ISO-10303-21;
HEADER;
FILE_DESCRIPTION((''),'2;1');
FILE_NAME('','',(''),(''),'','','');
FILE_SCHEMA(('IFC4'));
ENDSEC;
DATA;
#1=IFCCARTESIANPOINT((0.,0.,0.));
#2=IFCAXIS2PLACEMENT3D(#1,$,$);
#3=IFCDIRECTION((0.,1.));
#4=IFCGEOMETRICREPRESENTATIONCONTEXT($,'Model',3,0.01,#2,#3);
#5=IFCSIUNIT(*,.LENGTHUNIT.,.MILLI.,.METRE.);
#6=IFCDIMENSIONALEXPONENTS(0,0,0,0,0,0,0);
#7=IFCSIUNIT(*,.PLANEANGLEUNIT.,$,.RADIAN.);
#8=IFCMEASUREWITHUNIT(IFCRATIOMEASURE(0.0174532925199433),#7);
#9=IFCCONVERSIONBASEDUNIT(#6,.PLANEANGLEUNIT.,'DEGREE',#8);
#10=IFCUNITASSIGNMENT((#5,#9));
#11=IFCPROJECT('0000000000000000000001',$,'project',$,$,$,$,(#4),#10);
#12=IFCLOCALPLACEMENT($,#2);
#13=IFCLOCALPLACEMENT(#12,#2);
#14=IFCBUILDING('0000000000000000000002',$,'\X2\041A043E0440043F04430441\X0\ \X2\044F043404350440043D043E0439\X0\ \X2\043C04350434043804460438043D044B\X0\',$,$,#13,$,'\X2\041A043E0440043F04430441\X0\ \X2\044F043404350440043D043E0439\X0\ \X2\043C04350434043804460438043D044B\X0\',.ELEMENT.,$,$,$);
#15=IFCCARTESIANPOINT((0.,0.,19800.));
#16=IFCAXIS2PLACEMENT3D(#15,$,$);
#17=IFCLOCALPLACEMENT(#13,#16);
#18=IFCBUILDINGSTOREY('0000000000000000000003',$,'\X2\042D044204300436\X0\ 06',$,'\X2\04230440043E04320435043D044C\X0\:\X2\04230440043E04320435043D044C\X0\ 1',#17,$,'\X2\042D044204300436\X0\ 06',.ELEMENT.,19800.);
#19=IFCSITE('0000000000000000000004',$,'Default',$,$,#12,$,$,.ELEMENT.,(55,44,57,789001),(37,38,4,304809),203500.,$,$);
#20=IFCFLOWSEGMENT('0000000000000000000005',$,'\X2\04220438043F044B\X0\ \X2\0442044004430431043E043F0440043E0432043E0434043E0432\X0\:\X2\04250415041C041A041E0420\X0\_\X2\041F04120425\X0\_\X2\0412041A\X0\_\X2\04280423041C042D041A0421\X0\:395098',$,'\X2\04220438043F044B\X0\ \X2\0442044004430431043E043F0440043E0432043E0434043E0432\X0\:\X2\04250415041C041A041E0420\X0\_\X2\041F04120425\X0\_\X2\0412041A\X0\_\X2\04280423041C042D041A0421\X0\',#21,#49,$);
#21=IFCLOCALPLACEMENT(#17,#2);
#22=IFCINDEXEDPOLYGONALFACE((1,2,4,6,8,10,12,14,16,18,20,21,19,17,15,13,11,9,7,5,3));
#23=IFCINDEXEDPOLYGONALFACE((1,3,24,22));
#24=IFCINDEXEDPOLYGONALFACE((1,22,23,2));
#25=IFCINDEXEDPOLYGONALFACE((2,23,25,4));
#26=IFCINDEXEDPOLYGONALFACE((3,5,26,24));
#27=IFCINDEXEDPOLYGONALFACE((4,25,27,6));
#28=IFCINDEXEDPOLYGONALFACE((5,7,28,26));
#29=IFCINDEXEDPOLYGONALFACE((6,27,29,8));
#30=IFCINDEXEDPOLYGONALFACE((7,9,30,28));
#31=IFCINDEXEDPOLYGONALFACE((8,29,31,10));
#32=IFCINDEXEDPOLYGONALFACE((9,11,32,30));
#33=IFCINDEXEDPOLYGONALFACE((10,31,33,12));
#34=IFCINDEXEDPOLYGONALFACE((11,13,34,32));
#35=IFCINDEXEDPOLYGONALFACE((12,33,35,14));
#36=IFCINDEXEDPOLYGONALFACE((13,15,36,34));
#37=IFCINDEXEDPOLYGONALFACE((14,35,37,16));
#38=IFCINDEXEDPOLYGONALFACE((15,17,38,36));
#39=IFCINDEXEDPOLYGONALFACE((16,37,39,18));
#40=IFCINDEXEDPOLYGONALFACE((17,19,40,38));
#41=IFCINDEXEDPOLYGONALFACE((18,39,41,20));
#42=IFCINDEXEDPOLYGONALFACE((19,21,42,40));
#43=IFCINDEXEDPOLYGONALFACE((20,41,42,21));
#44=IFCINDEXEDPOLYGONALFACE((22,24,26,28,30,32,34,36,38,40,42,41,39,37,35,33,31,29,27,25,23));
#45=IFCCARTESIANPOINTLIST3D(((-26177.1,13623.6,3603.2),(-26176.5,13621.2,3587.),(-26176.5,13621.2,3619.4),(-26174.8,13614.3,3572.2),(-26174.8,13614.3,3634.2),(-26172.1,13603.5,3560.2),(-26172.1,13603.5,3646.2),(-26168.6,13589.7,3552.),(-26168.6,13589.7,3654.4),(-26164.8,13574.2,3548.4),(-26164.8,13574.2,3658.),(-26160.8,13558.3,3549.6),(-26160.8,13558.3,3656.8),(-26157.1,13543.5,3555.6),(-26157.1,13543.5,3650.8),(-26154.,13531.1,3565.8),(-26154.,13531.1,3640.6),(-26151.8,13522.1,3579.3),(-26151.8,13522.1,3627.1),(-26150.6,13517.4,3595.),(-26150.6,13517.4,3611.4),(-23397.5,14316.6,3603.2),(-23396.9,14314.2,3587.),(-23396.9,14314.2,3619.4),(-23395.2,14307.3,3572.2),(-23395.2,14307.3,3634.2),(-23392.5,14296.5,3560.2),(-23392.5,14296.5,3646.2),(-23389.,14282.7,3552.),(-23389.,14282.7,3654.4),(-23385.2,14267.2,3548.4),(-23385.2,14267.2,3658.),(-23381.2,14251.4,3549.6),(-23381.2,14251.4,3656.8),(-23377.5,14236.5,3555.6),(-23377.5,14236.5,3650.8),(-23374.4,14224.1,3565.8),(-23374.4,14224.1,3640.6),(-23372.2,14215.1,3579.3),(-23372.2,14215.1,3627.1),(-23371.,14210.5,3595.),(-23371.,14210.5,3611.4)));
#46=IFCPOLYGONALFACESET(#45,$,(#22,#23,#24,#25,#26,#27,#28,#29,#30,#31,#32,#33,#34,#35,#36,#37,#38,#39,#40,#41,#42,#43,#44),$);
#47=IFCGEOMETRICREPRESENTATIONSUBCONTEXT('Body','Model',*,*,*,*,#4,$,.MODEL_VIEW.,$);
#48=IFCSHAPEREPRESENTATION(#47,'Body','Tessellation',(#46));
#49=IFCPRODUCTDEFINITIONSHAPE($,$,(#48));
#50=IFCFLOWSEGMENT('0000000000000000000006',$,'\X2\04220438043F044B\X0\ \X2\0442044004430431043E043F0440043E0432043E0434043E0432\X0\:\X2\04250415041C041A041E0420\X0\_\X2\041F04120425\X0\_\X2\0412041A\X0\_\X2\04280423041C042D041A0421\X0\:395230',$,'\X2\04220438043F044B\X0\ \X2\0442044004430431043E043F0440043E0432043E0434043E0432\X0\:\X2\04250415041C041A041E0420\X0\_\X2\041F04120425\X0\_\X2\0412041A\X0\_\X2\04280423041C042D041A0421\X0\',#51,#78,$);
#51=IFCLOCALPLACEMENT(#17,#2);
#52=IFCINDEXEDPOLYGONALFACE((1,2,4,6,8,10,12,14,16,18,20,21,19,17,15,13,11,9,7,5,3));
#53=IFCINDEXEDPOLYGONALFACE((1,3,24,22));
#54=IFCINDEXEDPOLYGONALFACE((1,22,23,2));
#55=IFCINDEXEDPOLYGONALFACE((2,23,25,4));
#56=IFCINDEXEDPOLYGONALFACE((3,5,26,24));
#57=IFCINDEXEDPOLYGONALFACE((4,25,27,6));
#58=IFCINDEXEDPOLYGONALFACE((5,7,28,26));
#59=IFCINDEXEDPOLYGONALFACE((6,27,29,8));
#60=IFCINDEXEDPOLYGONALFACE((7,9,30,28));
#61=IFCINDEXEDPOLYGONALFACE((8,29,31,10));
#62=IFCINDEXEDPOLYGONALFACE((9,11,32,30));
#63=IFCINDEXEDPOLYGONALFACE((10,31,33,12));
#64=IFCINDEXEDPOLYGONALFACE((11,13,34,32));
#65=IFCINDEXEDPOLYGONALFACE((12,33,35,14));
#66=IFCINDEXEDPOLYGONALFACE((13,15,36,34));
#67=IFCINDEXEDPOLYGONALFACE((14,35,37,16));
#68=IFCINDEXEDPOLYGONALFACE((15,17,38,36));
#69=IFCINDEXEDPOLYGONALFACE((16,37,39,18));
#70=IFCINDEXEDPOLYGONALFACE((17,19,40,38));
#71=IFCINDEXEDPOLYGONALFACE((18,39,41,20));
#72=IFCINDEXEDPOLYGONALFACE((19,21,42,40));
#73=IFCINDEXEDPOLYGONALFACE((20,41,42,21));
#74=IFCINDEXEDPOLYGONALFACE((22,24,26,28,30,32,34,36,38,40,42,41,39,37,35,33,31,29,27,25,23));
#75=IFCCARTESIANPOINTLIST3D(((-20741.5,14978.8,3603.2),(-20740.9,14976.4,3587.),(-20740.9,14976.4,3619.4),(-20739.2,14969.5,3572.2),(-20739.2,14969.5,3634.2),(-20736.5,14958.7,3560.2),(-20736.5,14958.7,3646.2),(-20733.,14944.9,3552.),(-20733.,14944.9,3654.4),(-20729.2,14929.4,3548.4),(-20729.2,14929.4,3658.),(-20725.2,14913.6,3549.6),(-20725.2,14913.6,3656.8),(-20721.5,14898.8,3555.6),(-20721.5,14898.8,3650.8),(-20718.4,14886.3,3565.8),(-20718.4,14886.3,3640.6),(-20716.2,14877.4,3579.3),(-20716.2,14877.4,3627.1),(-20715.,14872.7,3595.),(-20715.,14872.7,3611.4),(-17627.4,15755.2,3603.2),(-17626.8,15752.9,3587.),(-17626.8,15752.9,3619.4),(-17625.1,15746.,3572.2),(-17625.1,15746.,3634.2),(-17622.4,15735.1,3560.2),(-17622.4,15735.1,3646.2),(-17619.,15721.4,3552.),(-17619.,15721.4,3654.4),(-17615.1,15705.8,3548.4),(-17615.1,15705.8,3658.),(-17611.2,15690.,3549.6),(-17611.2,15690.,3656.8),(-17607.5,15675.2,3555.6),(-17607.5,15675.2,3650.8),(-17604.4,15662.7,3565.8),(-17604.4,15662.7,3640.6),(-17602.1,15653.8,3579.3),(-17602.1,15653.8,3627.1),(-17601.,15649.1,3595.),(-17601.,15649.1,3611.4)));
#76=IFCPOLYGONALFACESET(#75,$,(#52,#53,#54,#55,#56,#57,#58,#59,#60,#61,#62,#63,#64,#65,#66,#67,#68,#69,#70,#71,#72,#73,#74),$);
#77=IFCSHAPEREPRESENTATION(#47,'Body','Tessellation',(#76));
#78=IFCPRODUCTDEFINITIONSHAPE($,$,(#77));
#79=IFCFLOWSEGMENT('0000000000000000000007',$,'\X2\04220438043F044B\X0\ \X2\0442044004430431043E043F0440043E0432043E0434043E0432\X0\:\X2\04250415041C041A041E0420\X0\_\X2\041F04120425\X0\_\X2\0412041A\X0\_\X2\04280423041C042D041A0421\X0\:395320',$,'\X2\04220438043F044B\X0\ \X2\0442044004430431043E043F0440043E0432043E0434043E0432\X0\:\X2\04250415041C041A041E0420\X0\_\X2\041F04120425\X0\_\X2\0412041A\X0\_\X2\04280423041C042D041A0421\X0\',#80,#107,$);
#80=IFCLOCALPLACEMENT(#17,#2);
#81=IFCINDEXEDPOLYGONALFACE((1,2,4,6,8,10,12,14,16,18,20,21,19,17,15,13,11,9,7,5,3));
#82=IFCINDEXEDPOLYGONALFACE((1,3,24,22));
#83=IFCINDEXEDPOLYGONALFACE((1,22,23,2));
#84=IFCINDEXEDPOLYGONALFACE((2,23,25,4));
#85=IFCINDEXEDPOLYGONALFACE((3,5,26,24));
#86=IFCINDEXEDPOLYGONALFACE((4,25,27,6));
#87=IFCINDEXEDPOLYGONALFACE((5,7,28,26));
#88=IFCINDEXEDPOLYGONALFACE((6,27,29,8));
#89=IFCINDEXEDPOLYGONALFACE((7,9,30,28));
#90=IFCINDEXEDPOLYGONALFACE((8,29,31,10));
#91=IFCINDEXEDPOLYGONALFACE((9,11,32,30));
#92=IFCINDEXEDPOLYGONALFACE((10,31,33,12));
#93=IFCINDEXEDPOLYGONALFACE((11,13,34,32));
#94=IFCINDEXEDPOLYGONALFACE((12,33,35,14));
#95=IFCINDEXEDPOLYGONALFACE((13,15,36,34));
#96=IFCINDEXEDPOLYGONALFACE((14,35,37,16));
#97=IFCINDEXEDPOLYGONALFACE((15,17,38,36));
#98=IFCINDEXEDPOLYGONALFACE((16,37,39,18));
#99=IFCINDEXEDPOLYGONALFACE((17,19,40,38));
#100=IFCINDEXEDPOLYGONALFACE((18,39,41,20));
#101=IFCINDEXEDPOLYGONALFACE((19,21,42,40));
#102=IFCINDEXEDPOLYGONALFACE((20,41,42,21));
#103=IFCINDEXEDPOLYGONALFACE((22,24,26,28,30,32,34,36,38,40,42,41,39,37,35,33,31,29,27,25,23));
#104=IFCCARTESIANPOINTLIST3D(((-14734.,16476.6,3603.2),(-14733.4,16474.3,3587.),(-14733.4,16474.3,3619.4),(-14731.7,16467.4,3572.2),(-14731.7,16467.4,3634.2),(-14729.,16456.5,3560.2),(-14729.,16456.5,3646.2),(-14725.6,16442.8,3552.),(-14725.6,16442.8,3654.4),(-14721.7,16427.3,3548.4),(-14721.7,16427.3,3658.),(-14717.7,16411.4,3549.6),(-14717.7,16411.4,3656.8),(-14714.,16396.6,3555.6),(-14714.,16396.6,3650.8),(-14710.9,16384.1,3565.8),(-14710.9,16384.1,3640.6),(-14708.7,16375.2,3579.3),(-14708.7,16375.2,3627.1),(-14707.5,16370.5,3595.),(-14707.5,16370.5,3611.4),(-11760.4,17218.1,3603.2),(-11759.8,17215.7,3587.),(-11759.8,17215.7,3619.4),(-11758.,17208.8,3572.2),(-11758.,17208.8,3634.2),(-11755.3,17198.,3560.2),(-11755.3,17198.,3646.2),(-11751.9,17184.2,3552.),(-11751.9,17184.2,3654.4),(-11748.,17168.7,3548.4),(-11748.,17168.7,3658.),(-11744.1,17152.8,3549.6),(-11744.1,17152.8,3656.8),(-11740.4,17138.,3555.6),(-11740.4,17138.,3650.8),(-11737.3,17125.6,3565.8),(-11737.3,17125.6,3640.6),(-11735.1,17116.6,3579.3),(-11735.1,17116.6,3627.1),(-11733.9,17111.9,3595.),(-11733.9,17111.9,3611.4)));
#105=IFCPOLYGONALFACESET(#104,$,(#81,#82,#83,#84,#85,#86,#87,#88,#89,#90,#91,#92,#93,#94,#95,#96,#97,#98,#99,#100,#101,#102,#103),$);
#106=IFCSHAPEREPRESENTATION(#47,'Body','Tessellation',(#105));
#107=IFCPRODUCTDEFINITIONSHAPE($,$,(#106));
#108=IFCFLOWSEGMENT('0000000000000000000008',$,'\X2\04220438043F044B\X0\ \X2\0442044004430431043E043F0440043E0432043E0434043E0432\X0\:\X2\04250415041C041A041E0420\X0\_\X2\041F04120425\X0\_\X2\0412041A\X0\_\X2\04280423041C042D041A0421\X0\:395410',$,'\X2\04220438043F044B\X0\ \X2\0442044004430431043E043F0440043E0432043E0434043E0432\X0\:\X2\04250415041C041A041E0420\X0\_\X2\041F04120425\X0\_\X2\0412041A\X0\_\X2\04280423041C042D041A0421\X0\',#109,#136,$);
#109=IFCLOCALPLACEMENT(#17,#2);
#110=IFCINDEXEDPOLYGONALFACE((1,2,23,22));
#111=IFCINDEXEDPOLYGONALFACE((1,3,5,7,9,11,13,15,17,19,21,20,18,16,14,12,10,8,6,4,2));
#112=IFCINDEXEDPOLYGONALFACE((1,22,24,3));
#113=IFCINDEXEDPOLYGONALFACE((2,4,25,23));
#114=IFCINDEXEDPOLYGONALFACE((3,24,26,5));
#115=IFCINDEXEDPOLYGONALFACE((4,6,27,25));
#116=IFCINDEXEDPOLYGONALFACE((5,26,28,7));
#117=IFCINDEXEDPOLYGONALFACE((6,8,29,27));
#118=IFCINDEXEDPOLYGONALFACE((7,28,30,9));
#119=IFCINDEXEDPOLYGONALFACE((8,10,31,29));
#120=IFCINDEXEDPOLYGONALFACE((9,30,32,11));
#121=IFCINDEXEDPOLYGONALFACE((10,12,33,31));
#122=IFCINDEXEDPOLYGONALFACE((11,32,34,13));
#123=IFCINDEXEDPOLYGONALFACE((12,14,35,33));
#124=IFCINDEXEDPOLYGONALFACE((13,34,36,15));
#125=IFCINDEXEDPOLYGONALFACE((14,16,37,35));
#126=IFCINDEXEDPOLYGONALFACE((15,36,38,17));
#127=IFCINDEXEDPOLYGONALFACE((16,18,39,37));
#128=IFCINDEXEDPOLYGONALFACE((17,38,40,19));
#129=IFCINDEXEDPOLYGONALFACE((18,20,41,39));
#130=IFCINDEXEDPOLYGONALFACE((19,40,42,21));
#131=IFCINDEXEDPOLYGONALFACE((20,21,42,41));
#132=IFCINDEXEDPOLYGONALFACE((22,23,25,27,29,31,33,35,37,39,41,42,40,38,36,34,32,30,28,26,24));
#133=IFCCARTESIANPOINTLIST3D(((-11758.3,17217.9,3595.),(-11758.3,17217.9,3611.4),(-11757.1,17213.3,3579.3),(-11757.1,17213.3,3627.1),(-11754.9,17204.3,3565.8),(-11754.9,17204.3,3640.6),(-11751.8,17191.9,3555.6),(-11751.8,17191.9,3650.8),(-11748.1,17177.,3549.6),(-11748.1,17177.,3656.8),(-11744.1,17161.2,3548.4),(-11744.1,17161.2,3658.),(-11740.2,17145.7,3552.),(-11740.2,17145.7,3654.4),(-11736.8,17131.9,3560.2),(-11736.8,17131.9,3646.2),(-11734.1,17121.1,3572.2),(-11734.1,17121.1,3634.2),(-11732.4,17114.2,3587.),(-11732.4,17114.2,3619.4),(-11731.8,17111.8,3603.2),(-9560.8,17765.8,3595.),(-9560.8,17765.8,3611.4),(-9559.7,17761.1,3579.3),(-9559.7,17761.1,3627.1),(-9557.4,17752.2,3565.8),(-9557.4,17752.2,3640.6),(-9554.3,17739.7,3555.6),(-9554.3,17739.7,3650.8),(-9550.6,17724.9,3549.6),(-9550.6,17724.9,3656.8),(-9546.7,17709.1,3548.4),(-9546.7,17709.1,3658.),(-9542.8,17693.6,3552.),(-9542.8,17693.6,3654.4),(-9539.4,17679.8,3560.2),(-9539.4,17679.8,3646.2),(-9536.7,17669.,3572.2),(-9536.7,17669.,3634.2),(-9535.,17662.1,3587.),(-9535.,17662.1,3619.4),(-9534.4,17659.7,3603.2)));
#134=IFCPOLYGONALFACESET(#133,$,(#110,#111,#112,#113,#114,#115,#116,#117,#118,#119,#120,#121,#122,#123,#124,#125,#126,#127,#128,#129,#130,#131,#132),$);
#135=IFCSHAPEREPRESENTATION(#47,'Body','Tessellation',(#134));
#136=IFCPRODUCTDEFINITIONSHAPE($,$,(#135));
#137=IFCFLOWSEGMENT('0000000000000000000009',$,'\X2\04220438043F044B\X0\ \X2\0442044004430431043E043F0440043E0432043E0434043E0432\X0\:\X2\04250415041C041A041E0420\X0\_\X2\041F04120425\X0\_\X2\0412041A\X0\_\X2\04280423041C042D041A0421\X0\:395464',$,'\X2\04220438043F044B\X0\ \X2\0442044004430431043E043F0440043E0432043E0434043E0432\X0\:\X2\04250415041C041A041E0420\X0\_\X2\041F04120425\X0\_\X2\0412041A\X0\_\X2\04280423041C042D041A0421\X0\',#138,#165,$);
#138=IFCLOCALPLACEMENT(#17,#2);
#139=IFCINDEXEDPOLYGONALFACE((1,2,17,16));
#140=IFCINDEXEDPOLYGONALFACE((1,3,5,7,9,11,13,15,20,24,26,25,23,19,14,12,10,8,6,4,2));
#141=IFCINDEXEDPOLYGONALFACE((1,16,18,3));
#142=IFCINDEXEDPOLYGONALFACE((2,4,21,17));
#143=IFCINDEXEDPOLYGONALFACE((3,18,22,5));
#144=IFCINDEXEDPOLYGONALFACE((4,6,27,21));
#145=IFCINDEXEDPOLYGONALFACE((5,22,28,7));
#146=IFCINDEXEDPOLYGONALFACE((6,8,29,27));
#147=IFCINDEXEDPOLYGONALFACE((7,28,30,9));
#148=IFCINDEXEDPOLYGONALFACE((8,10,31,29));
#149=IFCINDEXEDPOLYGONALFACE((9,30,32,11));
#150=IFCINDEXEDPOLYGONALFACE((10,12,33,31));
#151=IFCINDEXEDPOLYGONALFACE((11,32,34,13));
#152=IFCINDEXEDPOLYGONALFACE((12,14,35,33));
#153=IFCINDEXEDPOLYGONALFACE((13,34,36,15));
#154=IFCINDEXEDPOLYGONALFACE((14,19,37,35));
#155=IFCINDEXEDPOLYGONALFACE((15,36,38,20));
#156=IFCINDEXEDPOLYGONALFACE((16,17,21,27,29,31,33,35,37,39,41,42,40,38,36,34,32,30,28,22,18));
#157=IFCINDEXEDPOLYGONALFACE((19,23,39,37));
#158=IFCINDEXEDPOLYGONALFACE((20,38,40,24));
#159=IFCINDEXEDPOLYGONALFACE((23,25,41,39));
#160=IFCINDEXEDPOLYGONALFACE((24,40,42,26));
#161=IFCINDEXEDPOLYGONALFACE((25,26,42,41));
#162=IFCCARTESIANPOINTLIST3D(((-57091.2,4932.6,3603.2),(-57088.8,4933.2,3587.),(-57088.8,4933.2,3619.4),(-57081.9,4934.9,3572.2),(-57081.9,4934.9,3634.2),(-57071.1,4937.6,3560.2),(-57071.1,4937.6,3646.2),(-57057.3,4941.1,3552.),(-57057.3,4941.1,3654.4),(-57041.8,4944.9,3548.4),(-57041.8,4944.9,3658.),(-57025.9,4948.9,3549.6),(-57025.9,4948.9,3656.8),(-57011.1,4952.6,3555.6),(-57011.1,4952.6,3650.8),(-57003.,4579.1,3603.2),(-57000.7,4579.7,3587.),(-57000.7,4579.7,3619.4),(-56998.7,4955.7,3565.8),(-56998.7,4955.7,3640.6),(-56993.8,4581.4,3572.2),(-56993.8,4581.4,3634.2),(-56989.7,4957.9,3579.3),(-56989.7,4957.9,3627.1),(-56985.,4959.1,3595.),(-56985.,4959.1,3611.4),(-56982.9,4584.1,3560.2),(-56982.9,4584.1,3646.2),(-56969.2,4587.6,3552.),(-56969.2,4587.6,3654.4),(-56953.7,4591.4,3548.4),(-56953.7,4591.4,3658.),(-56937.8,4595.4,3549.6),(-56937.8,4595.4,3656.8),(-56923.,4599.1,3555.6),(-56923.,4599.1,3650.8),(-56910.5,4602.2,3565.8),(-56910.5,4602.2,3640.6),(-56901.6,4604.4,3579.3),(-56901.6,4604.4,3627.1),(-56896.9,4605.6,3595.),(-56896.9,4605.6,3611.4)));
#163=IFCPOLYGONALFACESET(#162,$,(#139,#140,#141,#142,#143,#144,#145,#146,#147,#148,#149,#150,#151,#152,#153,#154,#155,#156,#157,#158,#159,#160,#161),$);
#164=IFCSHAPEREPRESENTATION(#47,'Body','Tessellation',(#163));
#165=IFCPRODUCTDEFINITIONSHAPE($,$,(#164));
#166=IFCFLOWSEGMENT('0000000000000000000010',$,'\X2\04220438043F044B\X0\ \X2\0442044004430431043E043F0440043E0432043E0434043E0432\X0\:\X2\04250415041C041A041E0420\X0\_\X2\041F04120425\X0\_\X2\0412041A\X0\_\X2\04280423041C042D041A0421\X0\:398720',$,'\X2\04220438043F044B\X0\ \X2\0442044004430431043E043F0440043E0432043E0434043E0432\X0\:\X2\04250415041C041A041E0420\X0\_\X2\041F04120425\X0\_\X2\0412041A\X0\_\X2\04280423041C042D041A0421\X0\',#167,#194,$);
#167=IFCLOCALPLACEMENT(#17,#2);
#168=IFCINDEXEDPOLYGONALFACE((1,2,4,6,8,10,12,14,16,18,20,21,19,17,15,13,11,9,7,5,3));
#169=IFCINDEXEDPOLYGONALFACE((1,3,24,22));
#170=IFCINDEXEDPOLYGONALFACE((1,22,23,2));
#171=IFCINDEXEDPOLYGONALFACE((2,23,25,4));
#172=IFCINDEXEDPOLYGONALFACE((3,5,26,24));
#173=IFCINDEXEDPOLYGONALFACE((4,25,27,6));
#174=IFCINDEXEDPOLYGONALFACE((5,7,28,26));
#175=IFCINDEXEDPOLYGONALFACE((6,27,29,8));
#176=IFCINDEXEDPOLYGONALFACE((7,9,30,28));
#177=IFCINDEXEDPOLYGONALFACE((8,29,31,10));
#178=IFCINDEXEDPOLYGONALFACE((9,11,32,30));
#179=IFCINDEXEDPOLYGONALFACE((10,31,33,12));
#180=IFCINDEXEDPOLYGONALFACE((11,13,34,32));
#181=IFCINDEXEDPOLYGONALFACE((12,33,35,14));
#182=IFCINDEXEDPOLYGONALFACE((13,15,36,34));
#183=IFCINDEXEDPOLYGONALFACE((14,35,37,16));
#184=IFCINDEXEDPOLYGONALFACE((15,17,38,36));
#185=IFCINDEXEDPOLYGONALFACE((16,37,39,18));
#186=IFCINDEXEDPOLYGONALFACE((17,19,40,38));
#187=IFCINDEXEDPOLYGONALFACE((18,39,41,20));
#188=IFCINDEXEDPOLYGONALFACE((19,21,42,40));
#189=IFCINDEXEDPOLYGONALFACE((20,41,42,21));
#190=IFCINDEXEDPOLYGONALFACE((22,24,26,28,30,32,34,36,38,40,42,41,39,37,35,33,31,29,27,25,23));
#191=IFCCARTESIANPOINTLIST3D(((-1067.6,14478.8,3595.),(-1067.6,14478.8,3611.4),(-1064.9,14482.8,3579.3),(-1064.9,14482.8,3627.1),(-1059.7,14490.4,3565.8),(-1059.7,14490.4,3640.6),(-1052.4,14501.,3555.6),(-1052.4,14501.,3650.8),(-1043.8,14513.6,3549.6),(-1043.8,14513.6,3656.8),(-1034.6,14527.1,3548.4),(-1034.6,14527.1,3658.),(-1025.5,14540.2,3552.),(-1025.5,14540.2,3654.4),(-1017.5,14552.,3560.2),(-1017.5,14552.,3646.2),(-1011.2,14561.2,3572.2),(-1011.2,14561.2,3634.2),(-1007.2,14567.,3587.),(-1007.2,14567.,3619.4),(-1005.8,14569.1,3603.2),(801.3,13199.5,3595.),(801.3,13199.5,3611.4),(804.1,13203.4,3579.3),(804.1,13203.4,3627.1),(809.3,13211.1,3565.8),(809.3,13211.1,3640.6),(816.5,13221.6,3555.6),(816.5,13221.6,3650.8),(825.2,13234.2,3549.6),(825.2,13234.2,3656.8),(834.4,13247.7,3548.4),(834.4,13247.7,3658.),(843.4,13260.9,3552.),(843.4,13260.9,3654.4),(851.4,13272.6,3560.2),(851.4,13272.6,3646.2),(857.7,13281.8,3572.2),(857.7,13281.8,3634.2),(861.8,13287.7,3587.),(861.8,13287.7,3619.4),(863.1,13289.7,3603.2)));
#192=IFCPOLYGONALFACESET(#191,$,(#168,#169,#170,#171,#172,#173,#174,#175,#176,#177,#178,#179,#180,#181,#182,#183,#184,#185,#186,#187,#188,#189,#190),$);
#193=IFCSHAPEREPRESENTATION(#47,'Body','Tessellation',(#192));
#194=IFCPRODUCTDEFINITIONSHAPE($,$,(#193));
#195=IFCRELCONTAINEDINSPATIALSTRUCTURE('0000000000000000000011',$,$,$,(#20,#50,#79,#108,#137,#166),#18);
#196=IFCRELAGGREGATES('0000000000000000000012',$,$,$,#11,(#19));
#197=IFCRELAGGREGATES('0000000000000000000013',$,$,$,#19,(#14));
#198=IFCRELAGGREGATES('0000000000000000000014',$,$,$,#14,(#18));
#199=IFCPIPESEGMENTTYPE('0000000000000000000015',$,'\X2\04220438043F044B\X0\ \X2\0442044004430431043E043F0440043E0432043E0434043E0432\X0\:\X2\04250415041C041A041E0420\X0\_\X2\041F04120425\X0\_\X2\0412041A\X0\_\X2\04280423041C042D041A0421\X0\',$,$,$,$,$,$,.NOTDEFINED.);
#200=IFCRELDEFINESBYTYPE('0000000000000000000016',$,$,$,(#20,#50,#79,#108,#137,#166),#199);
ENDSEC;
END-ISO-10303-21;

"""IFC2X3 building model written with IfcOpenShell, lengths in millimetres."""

from ifc_helpers import new_model, entity, si_unit, converted_unit, direction, frame, origin, origin_2d_with_axis, place, context, subcontext, project, spatial, circle, extrude, type_object, element, save


model = new_model("IFC2X3")

# Units and contexts
model_context = context("Model", 3, precision=0.01, world=origin(), true_north=direction((0.0, 1.0)))
body_context = subcontext(model_context, "Body", "Model", "MODEL_VIEW")
ifc_project = project(units=[si_unit("LENGTHUNIT", "METRE", prefix="MILLI"), converted_unit("PLANEANGLEUNIT", "DEGREE", entity("IfcRatioMeasure", 0.0174532925199433), si_unit("PLANEANGLEUNIT", "RADIAN"), dimensions=[0, 0, 0, 0, 0, 0, 0])], contexts=[model_context])

# Site, building, storey
site_placement = place(None, origin())
site = spatial("IfcSite", under=ifc_project, at=site_placement, Name="Default", CompositionType="ELEMENT", RefLatitude=(55, 44, 57, 789001), RefLongitude=(37, 38, 4, 304809), RefElevation=203500.0)
building_placement = place(site_placement, origin())
building = spatial("IfcBuilding", under=site, at=building_placement, Name="Корпус ядерной медицины", LongName="Корпус ядерной медицины", CompositionType="ELEMENT")
storey_placement = place(building_placement, frame((0.0, 0.0, 19800.0)))
storey = spatial("IfcBuildingStorey", under=building, at=storey_placement, Name="Этаж 06", ObjectType="Уровень:Уровень 1", LongName="Этаж 06", CompositionType="ELEMENT", Elevation=19800.0)

# Flow segments
pipe_segment_type = type_object("IfcPipeSegmentType", Name="Типы трубопроводов:ХЕМКОР_ПВХ_ВК_ШУМЭКС", PredefinedType="NOTDEFINED")
flow_segment_1_placement = place(storey_placement, frame((-26178.7, 13515.2, 3546.6)))
element("IfcFlowSegment", 1, at=flow_segment_1_placement, inside=storey, type_object=pipe_segment_type, Name="Типы трубопроводов:ХЕМКОР_ПВХ_ВК_ШУМЭКС:395098", ObjectType="Типы трубопроводов:ХЕМКОР_ПВХ_ВК_ШУМЭКС", context=body_context, shape_type="SweptSolid", body=[
    extrude(circle(Radius=55.0, at=origin_2d_with_axis()), frame((14.9, 55.0, 56.6), z_axis=(0.970296, 0.241922, 0.0), x_axis=(-0.241922, 0.970296, 0.0)), (0.0, 0.0, 1.0), 2864.7),
])
flow_segment_2_placement = place(storey_placement, frame((-20743.1, 14870.5, 3546.6)))
element("IfcFlowSegment", 2, at=flow_segment_2_placement, inside=storey, type_object=pipe_segment_type, Name="Типы трубопроводов:ХЕМКОР_ПВХ_ВК_ШУМЭКС:395230", ObjectType="Типы трубопроводов:ХЕМКОР_ПВХ_ВК_ШУМЭКС", context=body_context, shape_type="SweptSolid", body=[
    extrude(circle(Radius=55.0, at=origin_2d_with_axis()), frame((14.9, 55.0, 56.6), z_axis=(0.970296, 0.241922, 0.0), x_axis=(-0.241922, 0.970296, 0.0)), (0.0, 0.0, 1.0), 3209.4),
])
flow_segment_3_placement = place(storey_placement, frame((-14735.6, 16368.3, 3546.6)))
element("IfcFlowSegment", 3, at=flow_segment_3_placement, inside=storey, type_object=pipe_segment_type, Name="Типы трубопроводов:ХЕМКОР_ПВХ_ВК_ШУМЭКС:395320", ObjectType="Типы трубопроводов:ХЕМКОР_ПВХ_ВК_ШУМЭКС", context=body_context, shape_type="SweptSolid", body=[
    extrude(circle(Radius=55.0, at=origin_2d_with_axis()), frame((14.9, 55.0, 56.6), z_axis=(0.970296, 0.241922, 0.0), x_axis=(-0.241922, 0.970296, 0.0)), (0.0, 0.0, 1.0), 3064.7),
])
flow_segment_4_placement = place(storey_placement, frame((-11760.0, 17110.2, 3546.6)))
element("IfcFlowSegment", 4, at=flow_segment_4_placement, inside=storey, type_object=pipe_segment_type, Name="Типы трубопроводов:ХЕМКОР_ПВХ_ВК_ШУМЭКС:395410", ObjectType="Типы трубопроводов:ХЕМКОР_ПВХ_ВК_ШУМЭКС", context=body_context, shape_type="SweptSolid", body=[
    extrude(circle(Radius=55.0, at=origin_2d_with_axis()), frame((14.9, 55.0, 56.6), z_axis=(0.970296, 0.241922, 0.0), x_axis=(0.241922, -0.970296, 0.0)), (0.0, 0.0, 1.0), 2264.7),
])
flow_segment_5_placement = place(storey_placement, frame((-57092.8, 4577.5, 3546.6)))
element("IfcFlowSegment", 5, at=flow_segment_5_placement, inside=storey, type_object=pipe_segment_type, Name="Типы трубопроводов:ХЕМКОР_ПВХ_ВК_ШУМЭКС:395464", ObjectType="Типы трубопроводов:ХЕМКОР_ПВХ_ВК_ШУМЭКС", context=body_context, shape_type="SweptSolid", body=[
    extrude(circle(Radius=55.0, at=origin_2d_with_axis()), frame((55.0, 368.4, 56.6), z_axis=(0.241922, -0.970296, 0.0), x_axis=(-0.970296, -0.241922, 0.0)), (0.0, 0.0, 1.0), 364.3),
])
flow_segment_6_placement = place(storey_placement, frame((-1069.5, 13197.4, 3546.6)))
element("IfcFlowSegment", 6, at=flow_segment_6_placement, inside=storey, type_object=pipe_segment_type, Name="Типы трубопроводов:ХЕМКОР_ПВХ_ВК_ШУМЭКС:398720", ObjectType="Типы трубопроводов:ХЕМКОР_ПВХ_ВК_ШУМЭКС", context=body_context, shape_type="SweptSolid", body=[
    extrude(circle(Radius=55.0, at=origin_2d_with_axis()), frame((1901.6, 47.0, 56.6), z_axis=(-0.825187, 0.564859, 0.0), x_axis=(0.564859, 0.825187, 0.0)), (0.0, 0.0, 1.0), 2264.9),
])

save(model, "model.ifc")
